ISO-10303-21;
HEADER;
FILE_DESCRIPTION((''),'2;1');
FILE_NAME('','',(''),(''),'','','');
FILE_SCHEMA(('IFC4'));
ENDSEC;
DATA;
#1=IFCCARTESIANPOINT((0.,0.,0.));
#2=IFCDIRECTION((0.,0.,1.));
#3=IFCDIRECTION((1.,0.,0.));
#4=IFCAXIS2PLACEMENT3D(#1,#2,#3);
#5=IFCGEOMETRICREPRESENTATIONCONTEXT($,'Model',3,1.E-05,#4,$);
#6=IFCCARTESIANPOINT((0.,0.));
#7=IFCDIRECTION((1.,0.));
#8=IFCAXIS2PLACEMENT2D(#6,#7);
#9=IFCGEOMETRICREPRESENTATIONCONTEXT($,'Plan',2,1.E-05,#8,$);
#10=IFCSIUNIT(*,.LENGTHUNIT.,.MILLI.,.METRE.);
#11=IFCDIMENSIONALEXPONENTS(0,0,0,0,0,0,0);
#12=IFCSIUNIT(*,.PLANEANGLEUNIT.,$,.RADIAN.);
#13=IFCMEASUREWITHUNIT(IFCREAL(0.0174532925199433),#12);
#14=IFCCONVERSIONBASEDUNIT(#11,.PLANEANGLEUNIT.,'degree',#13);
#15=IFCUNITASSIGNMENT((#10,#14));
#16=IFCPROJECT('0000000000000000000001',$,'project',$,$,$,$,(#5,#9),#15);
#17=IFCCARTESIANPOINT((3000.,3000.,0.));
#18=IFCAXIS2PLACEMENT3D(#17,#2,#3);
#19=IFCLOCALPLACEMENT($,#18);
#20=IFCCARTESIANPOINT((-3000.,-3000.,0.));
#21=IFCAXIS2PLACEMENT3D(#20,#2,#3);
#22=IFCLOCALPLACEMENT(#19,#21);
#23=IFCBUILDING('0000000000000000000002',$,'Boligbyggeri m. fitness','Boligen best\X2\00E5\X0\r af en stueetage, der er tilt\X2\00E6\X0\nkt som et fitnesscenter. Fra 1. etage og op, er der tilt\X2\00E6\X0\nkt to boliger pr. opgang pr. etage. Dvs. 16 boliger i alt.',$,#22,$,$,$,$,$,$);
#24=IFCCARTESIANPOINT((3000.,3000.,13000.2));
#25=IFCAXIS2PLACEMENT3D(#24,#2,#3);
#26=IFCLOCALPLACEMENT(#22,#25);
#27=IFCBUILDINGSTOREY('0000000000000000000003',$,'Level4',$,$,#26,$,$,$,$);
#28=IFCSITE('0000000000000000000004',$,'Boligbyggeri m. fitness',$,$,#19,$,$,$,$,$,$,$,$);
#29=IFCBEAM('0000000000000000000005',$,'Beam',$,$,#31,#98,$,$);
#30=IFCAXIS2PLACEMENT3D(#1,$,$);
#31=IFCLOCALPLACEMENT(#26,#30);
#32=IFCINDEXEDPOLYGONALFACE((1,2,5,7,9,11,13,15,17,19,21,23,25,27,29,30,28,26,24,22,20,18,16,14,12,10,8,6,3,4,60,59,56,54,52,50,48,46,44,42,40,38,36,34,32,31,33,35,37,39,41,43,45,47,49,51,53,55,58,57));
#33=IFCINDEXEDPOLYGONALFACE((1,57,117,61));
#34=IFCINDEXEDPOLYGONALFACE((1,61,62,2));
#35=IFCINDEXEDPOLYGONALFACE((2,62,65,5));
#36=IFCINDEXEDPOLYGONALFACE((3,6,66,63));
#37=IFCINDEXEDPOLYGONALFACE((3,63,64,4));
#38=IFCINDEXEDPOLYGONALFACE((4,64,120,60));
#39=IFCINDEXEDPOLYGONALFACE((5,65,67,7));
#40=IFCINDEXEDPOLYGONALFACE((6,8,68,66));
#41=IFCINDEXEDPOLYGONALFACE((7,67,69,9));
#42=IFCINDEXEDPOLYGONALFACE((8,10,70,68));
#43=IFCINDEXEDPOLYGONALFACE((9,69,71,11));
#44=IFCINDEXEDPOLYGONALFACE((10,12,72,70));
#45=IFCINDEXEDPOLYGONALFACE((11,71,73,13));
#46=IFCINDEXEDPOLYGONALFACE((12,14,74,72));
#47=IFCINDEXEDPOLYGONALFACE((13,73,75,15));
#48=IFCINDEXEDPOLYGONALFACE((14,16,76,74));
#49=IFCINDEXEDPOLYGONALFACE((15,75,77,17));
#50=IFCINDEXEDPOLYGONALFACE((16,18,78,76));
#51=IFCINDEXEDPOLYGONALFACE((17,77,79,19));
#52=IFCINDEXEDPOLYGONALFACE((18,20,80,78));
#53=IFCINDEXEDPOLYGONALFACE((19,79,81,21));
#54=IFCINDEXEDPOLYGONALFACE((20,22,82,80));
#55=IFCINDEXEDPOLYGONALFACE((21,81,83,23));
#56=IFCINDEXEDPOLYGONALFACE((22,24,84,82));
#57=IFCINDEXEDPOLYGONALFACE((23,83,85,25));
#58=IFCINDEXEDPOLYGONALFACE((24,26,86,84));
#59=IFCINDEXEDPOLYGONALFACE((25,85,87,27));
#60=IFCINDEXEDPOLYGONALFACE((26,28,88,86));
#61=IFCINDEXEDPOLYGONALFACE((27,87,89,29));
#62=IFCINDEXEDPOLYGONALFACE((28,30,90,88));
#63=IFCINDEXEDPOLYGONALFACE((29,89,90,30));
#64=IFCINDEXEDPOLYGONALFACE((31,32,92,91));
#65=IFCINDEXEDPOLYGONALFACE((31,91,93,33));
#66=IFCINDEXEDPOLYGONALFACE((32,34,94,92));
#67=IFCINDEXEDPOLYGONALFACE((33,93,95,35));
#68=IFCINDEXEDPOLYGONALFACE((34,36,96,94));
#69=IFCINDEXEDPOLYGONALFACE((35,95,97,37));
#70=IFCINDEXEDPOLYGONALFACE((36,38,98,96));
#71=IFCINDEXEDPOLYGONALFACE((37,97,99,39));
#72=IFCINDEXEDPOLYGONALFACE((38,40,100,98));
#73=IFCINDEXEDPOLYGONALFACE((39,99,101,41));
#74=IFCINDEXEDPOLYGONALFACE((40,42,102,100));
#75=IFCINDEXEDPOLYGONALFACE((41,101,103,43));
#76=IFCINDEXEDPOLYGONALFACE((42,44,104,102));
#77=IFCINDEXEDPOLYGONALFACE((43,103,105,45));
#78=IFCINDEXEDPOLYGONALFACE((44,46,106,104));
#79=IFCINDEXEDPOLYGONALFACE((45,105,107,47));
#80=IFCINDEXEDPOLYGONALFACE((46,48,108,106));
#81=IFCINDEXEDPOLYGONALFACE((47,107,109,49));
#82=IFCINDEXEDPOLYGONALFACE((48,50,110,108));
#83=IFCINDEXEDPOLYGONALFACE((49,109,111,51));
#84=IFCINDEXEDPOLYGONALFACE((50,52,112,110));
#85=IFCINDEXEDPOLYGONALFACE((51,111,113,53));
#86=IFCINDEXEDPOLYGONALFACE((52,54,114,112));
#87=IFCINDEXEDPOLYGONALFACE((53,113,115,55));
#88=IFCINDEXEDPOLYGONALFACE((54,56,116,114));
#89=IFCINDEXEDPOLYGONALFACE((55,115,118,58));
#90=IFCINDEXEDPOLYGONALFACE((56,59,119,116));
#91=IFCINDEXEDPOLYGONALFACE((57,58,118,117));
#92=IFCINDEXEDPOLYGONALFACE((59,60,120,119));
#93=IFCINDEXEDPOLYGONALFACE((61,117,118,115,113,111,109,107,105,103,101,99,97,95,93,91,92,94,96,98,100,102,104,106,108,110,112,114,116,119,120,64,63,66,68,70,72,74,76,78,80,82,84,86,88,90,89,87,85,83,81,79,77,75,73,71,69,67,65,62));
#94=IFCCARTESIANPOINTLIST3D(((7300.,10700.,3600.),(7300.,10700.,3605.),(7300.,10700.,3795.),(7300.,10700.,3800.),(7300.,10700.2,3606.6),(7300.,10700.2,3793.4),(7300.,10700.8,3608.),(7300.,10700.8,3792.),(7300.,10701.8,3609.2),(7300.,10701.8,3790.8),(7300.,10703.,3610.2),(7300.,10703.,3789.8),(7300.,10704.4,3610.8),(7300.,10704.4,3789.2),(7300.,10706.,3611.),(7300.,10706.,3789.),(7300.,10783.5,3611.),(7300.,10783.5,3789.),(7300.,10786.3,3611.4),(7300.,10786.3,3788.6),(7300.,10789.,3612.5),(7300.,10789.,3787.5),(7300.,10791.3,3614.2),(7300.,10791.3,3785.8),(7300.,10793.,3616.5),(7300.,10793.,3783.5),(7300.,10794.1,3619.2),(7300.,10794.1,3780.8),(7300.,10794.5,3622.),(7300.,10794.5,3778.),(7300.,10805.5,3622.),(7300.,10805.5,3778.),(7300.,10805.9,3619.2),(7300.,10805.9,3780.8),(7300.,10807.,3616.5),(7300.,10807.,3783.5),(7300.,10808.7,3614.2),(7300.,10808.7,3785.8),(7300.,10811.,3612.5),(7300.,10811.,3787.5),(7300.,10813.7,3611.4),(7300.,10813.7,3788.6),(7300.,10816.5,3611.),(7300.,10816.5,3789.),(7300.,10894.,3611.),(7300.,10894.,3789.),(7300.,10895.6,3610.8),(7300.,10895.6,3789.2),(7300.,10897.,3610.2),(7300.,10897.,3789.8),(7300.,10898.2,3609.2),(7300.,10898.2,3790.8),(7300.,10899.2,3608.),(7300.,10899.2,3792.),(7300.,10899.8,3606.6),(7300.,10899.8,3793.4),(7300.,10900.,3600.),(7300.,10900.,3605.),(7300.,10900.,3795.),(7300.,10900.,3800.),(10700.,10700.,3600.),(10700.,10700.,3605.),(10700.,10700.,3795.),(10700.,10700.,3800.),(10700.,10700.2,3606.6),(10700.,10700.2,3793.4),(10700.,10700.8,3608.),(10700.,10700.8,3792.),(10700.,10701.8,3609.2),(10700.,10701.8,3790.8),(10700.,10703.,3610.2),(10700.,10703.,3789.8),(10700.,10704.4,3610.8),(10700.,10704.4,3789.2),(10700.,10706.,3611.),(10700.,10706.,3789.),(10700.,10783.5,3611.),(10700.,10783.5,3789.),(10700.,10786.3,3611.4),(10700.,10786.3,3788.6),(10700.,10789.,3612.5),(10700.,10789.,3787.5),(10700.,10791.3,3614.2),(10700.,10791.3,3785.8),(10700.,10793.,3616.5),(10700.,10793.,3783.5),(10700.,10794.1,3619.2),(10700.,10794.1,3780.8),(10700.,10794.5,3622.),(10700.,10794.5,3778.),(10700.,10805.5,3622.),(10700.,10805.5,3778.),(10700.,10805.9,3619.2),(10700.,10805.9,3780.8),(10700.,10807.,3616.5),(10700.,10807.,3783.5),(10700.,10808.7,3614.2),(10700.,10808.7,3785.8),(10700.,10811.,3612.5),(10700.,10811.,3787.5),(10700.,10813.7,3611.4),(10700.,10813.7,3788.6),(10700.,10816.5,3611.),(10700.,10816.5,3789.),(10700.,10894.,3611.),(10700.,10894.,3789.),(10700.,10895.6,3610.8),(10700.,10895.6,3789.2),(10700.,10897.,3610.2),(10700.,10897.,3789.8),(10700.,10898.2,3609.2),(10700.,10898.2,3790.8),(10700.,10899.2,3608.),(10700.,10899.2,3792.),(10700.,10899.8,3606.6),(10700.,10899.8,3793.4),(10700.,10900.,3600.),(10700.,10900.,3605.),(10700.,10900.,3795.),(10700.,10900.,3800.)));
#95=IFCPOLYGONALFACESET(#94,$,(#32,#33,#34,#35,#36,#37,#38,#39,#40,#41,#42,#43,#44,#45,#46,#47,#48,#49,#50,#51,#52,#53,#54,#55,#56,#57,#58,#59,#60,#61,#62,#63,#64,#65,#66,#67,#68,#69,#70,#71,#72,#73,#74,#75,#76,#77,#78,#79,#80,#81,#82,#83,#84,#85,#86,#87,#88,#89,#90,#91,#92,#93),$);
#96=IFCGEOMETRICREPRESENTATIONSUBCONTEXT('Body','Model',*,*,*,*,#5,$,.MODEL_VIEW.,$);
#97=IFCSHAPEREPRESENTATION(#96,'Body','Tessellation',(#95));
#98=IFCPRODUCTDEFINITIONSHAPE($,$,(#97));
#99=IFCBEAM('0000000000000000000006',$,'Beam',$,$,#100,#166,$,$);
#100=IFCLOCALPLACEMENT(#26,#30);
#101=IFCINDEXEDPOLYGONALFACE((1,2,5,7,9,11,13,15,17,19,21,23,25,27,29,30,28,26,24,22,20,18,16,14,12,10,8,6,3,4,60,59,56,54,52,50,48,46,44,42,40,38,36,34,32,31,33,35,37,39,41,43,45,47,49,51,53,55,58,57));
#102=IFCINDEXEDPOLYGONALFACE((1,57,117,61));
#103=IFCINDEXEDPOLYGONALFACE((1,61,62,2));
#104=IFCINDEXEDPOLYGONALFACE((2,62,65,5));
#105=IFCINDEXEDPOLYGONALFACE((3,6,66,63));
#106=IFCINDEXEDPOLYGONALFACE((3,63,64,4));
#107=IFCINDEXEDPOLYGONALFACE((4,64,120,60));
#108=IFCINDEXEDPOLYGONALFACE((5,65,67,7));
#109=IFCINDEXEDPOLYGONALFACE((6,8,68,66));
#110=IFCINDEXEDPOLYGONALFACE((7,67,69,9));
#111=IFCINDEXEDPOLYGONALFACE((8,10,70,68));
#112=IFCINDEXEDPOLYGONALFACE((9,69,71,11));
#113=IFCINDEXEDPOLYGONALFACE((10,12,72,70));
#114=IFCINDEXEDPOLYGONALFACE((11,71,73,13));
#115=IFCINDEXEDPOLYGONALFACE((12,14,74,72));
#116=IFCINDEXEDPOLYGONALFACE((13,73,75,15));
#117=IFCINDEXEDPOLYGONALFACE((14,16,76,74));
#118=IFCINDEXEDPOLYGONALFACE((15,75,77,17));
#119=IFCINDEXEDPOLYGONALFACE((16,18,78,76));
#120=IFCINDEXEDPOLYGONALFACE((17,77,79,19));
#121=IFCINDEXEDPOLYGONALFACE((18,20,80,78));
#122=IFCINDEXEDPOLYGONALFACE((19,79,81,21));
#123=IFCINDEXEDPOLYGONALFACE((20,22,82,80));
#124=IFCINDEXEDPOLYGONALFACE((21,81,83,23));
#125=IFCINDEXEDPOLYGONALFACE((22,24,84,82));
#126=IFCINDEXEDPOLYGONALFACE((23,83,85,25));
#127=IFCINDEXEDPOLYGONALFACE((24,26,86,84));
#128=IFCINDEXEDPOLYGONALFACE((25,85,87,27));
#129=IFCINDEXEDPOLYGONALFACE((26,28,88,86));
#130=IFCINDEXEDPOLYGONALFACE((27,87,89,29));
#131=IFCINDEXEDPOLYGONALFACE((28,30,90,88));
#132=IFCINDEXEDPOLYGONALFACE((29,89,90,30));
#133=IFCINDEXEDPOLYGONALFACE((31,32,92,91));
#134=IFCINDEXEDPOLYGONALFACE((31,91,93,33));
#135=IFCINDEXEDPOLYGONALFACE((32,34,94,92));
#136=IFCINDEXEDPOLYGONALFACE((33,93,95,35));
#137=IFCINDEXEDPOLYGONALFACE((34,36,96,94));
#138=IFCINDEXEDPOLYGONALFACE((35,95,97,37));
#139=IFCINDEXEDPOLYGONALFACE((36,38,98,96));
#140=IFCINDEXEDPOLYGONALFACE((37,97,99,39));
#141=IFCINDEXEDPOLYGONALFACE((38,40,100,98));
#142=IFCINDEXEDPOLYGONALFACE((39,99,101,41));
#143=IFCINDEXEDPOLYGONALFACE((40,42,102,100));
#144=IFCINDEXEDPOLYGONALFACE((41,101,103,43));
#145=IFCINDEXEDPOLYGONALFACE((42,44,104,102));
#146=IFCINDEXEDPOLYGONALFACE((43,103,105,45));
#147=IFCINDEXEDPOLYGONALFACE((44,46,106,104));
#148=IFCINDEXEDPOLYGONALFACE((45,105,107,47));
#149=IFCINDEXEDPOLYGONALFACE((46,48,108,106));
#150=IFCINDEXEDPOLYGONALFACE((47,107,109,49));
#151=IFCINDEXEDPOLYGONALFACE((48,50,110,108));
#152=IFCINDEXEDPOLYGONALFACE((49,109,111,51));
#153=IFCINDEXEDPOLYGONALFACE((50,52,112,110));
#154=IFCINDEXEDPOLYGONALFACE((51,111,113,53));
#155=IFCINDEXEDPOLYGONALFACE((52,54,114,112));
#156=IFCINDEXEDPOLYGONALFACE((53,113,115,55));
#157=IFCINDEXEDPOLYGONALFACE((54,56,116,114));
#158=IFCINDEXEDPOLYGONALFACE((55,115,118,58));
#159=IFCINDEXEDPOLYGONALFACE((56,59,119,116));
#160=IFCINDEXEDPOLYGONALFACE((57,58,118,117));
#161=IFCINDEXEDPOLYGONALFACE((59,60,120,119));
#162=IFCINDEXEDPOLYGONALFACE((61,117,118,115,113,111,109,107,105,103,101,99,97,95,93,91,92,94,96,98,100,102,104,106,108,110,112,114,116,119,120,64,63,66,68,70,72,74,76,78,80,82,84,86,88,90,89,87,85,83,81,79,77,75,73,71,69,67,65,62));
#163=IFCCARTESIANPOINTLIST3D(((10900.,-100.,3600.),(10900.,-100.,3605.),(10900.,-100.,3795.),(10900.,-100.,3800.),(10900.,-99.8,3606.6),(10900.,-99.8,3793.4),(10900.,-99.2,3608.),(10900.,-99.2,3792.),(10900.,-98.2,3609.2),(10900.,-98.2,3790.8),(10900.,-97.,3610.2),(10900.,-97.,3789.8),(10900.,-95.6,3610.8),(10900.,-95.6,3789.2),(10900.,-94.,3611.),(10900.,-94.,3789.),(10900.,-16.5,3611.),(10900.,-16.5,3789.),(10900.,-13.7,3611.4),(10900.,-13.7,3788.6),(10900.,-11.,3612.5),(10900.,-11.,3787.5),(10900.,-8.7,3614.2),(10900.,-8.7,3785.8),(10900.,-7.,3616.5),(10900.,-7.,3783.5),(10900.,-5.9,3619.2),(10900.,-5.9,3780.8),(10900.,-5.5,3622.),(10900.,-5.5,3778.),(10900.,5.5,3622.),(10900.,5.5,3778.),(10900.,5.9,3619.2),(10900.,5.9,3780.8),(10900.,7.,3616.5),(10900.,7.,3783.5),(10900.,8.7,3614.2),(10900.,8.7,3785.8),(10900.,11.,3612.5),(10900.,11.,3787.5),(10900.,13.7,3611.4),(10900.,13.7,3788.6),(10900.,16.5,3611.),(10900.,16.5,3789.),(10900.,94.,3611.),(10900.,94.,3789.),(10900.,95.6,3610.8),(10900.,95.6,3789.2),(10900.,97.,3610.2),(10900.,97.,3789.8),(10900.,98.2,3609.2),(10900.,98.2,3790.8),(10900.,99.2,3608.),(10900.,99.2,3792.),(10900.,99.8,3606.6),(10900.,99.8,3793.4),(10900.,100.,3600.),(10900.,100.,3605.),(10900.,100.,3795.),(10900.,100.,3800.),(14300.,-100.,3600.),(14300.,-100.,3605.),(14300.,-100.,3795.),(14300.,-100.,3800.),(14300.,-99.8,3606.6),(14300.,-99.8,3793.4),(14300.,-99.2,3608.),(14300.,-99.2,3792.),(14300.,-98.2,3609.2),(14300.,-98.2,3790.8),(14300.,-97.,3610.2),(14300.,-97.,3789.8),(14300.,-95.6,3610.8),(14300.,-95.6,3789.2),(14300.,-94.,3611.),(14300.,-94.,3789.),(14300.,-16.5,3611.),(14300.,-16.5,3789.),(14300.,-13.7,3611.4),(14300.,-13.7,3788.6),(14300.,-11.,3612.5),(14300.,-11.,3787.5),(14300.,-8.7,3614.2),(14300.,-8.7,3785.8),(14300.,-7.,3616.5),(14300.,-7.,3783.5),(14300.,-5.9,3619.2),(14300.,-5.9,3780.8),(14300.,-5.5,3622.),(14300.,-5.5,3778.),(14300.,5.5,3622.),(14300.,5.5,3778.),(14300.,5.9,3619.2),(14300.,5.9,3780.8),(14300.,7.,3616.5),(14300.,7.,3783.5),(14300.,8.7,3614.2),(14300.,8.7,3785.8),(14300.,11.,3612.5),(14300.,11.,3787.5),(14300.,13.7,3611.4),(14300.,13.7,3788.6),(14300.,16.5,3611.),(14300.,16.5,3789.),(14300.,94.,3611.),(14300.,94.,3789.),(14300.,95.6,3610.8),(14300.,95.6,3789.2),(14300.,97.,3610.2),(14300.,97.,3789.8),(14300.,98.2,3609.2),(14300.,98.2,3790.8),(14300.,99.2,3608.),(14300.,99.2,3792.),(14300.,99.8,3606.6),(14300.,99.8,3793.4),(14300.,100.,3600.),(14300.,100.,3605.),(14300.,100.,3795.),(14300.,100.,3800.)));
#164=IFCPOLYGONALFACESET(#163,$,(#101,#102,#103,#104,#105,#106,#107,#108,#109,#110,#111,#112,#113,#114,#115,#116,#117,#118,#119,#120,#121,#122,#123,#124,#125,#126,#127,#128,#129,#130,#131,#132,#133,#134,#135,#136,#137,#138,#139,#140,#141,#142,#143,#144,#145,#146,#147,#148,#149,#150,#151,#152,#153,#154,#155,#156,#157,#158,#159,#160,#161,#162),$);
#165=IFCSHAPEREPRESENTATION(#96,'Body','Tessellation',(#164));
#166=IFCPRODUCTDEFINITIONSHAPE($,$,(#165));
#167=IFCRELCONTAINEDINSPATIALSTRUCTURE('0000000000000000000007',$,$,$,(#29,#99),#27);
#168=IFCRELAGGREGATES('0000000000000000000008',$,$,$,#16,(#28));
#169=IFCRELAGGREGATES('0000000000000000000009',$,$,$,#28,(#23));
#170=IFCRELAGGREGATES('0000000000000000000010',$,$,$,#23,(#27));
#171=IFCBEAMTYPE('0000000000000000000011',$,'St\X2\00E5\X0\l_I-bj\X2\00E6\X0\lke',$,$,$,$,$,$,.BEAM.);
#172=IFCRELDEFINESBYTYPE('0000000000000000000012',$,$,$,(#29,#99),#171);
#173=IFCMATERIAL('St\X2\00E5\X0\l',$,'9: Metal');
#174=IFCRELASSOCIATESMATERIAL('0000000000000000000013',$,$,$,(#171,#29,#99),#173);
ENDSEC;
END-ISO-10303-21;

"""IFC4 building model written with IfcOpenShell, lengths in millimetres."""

from ifc_helpers import new_model, entity, si_unit, converted_unit, frame, origin_with_axes, origin_2d_with_axis, place, context, subcontext, project, spatial, i_section, extrude, material, material_profile, profile_set, profile_usage, type_object, element, save


model = new_model("IFC4")

# Units and contexts
model_context = context("Model", 3, precision=1e-05, world=origin_with_axes())
plan_context = context("Plan", 2, precision=1e-05, world=origin_2d_with_axis())
body_context = subcontext(model_context, "Body", "Model", "MODEL_VIEW")
ifc_project = project(units=[si_unit("LENGTHUNIT", "METRE", prefix="MILLI"), converted_unit("PLANEANGLEUNIT", "degree", entity("IfcReal", 0.0174532925199433), si_unit("PLANEANGLEUNIT", "RADIAN"), dimensions=[0, 0, 0, 0, 0, 0, 0])], contexts=[model_context, plan_context])

# Site, building, storey
site_placement = place(None, frame((3000.0, 3000.0, 0.0), z_axis=(0.0, 0.0, 1.0), x_axis=(1.0, 0.0, 0.0)))
site = spatial("IfcSite", under=ifc_project, at=site_placement, Name="Boligbyggeri m. fitness")
building_placement = place(site_placement, frame((-3000.0, -3000.0, 0.0), z_axis=(0.0, 0.0, 1.0), x_axis=(1.0, 0.0, 0.0)))
building = spatial("IfcBuilding", under=site, at=building_placement, Name="Boligbyggeri m. fitness", Description="Boligen består af en stueetage, der er tiltænkt som et fitnesscenter. Fra 1. etage og op, er der tiltænkt to boliger pr. opgang pr. etage. Dvs. 16 boliger i alt.")
storey_placement = place(building_placement, frame((3000.0, 3000.0, 13000.2), z_axis=(0.0, 0.0, 1.0), x_axis=(1.0, 0.0, 0.0)))
storey = spatial("IfcBuildingStorey", under=building, at=storey_placement, Name="Level4")

# Beams
ifc_material_1 = material(Name="Stål", Category="9: Metal")
ifc_material_profile_1 = material_profile(ifc_material_1, i_section(OverallWidth=200.0, OverallDepth=200.0, WebThickness=11.0, FlangeThickness=11.0, FilletRadius=11.0, FlangeEdgeRadius=6.0), Name="Stål", Category="9: Metal")
ifc_profile_set_1 = profile_set([ifc_material_profile_1], Name="NY_I-Profil")
beam_type = type_object("IfcBeamType", Name="Stål_I-bjælke", PredefinedType="BEAM", material=ifc_profile_set_1)
ifc_profile_usage_1 = profile_usage(ifc_profile_set_1, cardinal=7)
beam_1_placement = place(storey_placement, frame((7300.0, 10900.0, 3800.0), z_axis=(1.0, 0.0, 0.0), x_axis=(0.0, 1.0, 0.0)))
element("IfcBeam", 1, at=beam_1_placement, inside=storey, type_object=beam_type, material=ifc_profile_usage_1, Name="Beam", context=body_context, shape_type="SweptSolid", body=[
    extrude(i_section(OverallWidth=200.0, OverallDepth=200.0, WebThickness=11.0, FlangeThickness=11.0, FilletRadius=11.0, FlangeEdgeRadius=6.0), frame((-100.0, -100.0, 0.0), z_axis=(0.0, 0.0, 1.0), x_axis=(1.0, 0.0, 0.0)), (0.0, 0.0, 1.0), 3400.0),
])
ifc_profile_usage_2 = profile_usage(ifc_profile_set_1, cardinal=7)
beam_2_placement = place(storey_placement, frame((10900.0, 100.0, 3800.0), z_axis=(1.0, 0.0, 0.0), x_axis=(0.0, 1.0, 0.0)))
element("IfcBeam", 2, at=beam_2_placement, inside=storey, type_object=beam_type, material=ifc_profile_usage_2, Name="Beam", context=body_context, shape_type="SweptSolid", body=[
    extrude(i_section(OverallWidth=200.0, OverallDepth=200.0, WebThickness=11.0, FlangeThickness=11.0, FilletRadius=11.0, FlangeEdgeRadius=6.0), frame((-100.0, -100.0, 0.0), z_axis=(0.0, 0.0, 1.0), x_axis=(1.0, 0.0, 0.0)), (0.0, 0.0, 1.0), 3400.0),
])

save(model, "model.ifc")
